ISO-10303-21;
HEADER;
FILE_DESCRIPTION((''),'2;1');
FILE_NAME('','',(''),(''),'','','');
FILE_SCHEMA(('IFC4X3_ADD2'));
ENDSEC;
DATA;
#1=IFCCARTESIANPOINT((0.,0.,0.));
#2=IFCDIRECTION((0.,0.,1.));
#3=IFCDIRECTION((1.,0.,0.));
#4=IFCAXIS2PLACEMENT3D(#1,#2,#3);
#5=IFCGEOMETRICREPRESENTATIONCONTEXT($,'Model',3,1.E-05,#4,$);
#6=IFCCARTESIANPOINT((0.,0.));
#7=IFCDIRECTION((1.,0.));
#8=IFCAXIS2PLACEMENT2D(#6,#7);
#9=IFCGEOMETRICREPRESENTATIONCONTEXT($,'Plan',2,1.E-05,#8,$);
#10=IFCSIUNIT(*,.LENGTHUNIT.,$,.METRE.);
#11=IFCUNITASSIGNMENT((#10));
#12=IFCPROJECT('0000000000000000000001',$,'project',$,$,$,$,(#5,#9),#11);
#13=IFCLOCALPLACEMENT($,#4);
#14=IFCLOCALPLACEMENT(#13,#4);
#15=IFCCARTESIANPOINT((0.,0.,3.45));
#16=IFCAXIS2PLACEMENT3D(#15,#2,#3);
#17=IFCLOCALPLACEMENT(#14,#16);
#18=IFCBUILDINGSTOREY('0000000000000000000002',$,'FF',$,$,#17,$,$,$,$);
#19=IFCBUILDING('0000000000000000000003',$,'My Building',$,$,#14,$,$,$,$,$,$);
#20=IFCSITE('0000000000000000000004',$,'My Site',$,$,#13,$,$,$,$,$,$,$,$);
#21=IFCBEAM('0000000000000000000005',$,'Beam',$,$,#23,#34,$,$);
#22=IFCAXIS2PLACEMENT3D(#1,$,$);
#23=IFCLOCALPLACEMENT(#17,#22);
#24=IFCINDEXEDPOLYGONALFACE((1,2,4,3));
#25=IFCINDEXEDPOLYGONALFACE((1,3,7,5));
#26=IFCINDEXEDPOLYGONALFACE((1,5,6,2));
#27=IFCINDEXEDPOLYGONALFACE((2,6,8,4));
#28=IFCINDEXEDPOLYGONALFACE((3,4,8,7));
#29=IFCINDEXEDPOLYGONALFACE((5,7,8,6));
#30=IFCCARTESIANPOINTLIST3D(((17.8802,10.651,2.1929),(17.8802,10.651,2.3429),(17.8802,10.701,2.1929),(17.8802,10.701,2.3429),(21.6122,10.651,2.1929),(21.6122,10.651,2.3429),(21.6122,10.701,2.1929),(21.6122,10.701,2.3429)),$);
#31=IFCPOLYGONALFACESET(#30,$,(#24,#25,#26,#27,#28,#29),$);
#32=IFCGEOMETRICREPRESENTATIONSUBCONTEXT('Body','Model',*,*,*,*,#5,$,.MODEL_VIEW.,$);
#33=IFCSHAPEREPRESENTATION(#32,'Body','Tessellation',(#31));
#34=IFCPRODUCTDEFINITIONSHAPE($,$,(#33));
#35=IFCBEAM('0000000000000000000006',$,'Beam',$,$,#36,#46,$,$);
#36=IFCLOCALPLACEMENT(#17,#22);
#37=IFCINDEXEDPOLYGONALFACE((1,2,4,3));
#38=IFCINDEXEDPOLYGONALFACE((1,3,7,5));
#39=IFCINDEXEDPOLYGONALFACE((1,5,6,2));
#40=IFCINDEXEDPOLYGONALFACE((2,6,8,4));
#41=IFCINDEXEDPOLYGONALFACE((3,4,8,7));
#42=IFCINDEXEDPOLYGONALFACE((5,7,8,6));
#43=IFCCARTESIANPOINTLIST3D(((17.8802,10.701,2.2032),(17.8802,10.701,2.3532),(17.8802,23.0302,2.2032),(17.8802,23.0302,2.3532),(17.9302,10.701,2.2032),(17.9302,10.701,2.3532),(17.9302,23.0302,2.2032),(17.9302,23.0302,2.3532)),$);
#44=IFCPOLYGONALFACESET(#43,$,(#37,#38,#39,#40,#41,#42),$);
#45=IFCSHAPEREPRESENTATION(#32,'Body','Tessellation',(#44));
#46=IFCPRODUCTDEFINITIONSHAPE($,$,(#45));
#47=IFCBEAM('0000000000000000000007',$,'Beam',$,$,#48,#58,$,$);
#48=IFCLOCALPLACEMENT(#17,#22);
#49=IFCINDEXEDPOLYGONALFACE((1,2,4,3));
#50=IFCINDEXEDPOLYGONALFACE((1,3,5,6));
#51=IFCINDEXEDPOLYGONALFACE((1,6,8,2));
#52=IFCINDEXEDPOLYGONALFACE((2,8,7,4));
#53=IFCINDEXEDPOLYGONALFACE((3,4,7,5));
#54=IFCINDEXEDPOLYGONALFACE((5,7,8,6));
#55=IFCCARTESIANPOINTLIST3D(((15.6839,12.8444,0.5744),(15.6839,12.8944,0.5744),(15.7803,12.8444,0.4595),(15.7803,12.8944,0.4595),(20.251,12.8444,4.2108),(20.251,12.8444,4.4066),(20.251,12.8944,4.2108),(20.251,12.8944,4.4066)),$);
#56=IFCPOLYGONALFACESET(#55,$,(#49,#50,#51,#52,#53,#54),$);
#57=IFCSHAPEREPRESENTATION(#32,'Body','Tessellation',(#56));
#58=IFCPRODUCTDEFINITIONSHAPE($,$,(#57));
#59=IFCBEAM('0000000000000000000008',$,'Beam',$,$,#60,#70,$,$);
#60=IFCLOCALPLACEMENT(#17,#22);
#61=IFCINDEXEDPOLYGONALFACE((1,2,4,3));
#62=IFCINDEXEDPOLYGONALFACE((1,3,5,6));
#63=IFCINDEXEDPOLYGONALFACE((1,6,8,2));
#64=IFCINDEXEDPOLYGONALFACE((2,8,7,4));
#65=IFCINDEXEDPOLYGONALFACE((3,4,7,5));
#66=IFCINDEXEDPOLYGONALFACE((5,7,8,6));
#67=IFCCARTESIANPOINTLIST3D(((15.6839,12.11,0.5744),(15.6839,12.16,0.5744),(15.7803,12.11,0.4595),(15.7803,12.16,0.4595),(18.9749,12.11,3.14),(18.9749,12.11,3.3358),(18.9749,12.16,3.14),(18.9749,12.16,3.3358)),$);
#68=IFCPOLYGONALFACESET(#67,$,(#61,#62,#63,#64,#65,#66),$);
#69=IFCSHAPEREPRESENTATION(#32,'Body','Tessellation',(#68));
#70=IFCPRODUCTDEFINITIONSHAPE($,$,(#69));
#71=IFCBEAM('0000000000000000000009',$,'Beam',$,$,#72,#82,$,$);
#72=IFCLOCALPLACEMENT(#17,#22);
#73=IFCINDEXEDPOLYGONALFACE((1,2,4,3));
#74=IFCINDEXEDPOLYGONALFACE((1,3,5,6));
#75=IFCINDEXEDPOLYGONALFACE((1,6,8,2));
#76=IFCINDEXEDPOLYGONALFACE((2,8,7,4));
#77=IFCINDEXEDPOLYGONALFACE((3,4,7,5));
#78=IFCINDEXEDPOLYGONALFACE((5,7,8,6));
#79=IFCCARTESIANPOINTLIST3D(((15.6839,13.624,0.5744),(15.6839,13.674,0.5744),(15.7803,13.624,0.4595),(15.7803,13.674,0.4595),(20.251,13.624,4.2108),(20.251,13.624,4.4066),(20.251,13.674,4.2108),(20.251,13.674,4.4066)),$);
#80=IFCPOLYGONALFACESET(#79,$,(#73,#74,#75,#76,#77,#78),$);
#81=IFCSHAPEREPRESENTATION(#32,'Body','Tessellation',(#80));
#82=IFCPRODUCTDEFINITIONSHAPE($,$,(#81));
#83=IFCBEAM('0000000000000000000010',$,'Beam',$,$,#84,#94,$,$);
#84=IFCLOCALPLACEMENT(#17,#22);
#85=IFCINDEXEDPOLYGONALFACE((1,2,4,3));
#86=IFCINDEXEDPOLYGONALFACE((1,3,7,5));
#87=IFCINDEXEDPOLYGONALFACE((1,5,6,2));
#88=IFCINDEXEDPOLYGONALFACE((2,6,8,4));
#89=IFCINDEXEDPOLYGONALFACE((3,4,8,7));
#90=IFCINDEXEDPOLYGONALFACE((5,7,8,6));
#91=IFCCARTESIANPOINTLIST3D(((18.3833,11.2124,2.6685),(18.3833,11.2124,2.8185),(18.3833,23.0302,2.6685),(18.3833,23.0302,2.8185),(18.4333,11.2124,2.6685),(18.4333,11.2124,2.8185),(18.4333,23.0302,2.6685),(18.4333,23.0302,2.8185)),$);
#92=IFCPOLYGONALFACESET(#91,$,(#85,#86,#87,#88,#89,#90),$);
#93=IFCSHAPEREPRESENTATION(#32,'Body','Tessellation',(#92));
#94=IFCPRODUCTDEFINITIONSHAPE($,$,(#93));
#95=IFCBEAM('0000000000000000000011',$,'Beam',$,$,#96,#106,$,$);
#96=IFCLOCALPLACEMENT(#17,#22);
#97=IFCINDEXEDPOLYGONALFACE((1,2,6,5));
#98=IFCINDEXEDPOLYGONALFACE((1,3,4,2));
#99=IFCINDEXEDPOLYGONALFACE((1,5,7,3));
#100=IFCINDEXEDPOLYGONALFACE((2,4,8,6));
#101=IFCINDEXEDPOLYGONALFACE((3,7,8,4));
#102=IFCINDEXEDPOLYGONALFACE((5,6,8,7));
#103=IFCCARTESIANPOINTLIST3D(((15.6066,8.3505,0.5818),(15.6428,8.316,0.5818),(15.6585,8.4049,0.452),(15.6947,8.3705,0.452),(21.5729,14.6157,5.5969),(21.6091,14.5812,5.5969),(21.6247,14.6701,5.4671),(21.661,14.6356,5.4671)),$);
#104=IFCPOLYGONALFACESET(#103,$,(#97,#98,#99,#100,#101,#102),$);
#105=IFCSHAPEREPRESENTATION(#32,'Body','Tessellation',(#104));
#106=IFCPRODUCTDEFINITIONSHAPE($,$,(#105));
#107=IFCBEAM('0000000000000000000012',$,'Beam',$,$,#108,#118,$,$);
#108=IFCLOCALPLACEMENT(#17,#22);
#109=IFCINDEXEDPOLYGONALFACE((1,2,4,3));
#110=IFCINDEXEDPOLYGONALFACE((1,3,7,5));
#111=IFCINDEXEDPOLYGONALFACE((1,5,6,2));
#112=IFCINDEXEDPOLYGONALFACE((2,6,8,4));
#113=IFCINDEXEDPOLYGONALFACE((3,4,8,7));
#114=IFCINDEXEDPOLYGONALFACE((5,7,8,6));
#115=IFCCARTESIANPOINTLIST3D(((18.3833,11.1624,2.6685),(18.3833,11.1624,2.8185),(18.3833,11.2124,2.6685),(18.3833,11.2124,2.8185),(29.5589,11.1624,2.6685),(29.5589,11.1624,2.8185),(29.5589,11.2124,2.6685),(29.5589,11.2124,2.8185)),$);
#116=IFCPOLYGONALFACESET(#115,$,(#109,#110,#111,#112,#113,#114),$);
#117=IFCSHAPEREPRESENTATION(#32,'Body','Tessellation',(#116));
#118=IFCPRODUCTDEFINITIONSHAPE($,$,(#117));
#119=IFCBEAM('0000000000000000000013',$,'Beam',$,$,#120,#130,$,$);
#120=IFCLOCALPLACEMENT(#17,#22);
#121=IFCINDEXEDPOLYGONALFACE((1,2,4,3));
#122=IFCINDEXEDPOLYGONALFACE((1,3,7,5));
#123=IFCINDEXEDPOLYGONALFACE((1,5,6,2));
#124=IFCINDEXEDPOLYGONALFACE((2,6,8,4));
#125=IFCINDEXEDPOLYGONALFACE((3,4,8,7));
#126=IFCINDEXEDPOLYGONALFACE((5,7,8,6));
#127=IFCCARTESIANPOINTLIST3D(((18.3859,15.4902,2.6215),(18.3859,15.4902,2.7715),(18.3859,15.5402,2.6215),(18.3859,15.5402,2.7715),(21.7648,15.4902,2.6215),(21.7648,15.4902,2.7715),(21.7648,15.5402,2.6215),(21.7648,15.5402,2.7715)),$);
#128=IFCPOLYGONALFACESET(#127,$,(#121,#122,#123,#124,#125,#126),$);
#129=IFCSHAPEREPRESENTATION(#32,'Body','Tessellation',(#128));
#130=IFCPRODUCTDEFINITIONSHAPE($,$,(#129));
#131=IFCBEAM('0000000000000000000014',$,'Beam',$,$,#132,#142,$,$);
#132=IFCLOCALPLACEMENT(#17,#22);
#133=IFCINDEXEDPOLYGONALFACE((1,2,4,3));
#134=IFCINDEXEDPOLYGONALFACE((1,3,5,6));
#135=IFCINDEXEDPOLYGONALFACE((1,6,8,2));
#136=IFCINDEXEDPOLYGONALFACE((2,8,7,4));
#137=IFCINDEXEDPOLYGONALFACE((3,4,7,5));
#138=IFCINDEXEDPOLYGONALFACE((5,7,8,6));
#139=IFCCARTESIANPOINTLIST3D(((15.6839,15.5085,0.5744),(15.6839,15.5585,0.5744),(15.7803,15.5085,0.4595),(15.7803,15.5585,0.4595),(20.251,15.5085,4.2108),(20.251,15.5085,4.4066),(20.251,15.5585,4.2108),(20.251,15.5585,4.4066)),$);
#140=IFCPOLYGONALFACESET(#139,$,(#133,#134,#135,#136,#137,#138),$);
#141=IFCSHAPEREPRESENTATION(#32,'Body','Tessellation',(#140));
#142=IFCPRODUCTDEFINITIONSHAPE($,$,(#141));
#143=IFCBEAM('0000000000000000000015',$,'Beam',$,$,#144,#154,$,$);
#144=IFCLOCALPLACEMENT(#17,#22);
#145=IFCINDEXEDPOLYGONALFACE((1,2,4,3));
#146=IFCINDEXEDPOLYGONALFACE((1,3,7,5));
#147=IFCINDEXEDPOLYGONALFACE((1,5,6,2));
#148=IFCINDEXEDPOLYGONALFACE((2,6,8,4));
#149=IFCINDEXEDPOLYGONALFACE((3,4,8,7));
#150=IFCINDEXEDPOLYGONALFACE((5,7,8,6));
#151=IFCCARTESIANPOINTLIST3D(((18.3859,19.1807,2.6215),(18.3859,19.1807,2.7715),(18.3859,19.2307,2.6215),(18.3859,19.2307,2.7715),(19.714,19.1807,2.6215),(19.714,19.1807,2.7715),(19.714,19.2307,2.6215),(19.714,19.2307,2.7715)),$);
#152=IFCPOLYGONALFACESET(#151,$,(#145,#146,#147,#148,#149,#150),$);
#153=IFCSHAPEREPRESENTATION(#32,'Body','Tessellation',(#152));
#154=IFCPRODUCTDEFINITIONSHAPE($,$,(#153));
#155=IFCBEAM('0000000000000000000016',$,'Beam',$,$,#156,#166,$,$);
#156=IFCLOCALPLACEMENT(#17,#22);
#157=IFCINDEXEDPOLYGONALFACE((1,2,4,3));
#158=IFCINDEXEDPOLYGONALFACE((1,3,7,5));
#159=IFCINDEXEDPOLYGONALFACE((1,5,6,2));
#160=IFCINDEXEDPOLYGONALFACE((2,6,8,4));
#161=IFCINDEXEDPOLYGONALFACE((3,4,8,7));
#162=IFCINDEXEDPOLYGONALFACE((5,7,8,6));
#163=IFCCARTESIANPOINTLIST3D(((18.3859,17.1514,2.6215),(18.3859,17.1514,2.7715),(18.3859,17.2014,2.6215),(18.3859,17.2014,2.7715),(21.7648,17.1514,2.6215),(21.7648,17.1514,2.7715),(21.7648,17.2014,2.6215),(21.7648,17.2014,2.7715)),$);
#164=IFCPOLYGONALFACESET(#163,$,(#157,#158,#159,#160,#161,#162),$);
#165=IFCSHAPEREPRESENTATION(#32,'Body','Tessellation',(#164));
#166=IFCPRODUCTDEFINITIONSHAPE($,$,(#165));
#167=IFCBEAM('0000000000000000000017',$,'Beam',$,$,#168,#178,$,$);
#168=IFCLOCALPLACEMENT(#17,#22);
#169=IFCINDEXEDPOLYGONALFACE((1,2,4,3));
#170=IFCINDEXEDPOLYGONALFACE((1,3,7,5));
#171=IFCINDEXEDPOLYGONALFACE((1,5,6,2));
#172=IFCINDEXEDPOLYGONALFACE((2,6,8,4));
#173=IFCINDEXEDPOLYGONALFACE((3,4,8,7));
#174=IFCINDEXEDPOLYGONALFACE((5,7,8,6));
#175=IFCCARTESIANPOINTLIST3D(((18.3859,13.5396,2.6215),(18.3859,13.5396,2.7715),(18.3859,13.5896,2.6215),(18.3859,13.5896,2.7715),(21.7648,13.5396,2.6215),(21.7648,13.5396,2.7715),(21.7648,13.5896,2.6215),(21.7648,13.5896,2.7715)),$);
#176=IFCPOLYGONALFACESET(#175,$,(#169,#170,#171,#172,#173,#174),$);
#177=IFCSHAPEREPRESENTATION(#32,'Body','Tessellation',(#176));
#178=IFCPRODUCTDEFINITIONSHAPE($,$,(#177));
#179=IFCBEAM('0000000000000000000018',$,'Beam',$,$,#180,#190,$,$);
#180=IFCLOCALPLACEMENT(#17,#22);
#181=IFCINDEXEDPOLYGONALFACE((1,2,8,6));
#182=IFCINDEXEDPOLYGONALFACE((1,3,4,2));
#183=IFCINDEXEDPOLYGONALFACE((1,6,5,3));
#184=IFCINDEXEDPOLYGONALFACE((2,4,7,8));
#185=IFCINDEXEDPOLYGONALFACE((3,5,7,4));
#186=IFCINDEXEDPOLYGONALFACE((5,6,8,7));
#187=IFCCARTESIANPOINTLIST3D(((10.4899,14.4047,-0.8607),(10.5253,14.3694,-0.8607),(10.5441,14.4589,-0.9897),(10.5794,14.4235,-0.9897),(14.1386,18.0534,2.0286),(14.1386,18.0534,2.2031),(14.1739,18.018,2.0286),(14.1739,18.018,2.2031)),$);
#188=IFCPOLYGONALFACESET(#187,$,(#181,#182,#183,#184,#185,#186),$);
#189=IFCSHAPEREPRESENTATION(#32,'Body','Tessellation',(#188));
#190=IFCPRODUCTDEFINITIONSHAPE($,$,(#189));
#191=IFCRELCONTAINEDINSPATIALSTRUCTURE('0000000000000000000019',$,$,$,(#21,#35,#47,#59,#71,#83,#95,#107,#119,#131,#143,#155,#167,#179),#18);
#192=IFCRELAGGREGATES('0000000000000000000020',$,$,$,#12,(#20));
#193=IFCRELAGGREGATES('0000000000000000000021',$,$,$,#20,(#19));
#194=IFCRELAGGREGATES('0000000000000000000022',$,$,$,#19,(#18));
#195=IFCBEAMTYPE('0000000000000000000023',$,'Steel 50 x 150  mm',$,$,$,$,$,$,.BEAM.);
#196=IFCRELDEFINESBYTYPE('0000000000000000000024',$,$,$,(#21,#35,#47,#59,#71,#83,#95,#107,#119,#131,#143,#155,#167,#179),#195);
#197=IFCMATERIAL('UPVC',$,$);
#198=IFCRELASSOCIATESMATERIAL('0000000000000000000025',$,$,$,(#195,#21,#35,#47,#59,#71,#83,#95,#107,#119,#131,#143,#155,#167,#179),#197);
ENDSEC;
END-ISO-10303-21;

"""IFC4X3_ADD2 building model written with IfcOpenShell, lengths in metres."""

from ifc_helpers import new_model, si_unit, frame, origin_with_axes, origin_2d_with_axis, place, context, subcontext, project, spatial, rectangle, extrude, clip, halfspace, material, material_profile, profile_set, profile_usage, type_object, element, save


model = new_model("IFC4X3_ADD2")

# Units and contexts
model_context = context("Model", 3, precision=1e-05, world=origin_with_axes())
plan_context = context("Plan", 2, precision=1e-05, world=origin_2d_with_axis())
body_context_1 = subcontext(model_context, "Body", "Model", "MODEL_VIEW")
ifc_project = project(units=[si_unit("LENGTHUNIT", "METRE")], contexts=[model_context, plan_context])

# Site, building, storey
site_placement = place(None, origin_with_axes())
site = spatial("IfcSite", under=ifc_project, at=site_placement, Name="My Site")
building_placement = place(site_placement, origin_with_axes())
building = spatial("IfcBuilding", under=site, at=building_placement, Name="My Building")
storey_placement = place(building_placement, frame((0.0, 0.0, 3.45), z_axis=(0.0, 0.0, 1.0), x_axis=(1.0, 0.0, 0.0)))
storey = spatial("IfcBuildingStorey", under=building, at=storey_placement, Name="FF")

# Beams
ifc_material_1 = material(Name="UPVC")
ifc_material_profile = material_profile(ifc_material_1, rectangle(XDim=0.05, YDim=0.15))
ifc_profile_set = profile_set([ifc_material_profile])
ifc_profile_usage_1 = profile_usage(ifc_profile_set)
beam_type = type_object("IfcBeamType", Name="Steel 50 x 150  mm", PredefinedType="BEAM", material=ifc_profile_set)
beam_1_placement = place(storey_placement, frame((17.8802, 10.676, 2.2679), z_axis=(1.0, 0.0, 0.0), x_axis=(0.0, 1.0, 0.0)))
element("IfcBeam", 1, at=beam_1_placement, inside=storey, type_object=beam_type, material=ifc_profile_usage_1, Name="Beam", context=body_context_1, shape_type="SweptSolid", body=[
    extrude(rectangle(XDim=0.05, YDim=0.15), origin_with_axes(), (0.0, 0.0, 1.0), 3.732),
])
ifc_profile_usage_2 = profile_usage(ifc_profile_set)
beam_2_placement = place(storey_placement, frame((17.9052, 10.701, 2.2782), z_axis=(0.0, 1.0, 0.0), x_axis=(-1.0, 0.0, 0.0)))
element("IfcBeam", 2, at=beam_2_placement, inside=storey, type_object=beam_type, material=ifc_profile_usage_2, Name="Beam", context=body_context_1, shape_type="SweptSolid", body=[
    extrude(rectangle(XDim=0.05, YDim=0.15), origin_with_axes(), (0.0, 0.0, 1.0), 12.3292),
])
ifc_profile_usage_3 = profile_usage(ifc_profile_set)
beam_3_placement = place(storey_placement, frame((15.7321, 12.8694, 0.5169), z_axis=(0.766044, 0.0, 0.642788), x_axis=(0.000001, 1.0, 0.0)))
element("IfcBeam", 3, at=beam_3_placement, inside=storey, type_object=beam_type, material=ifc_profile_usage_3, Name="Beam", context=body_context_1, shape_type="Clipping", body=[
    clip(extrude(rectangle(XDim=0.05, YDim=0.15), origin_with_axes(), (0.0, 0.0, 1.0), 6.049), halfspace(frame((-4.4092, -2.9047, 3.4617), z_axis=(0.0, -0.642788, 0.766044), x_axis=(-1.0, 0.0, 0.0)), False)),
])
ifc_profile_usage_4 = profile_usage(ifc_profile_set)
beam_4_placement = place(storey_placement, frame((15.7321, 12.135, 0.5169), z_axis=(0.766044, 0.0, 0.642788), x_axis=(0.000001, 1.0, 0.0)))
element("IfcBeam", 4, at=beam_4_placement, inside=storey, type_object=beam_type, material=ifc_profile_usage_4, Name="Beam", context=body_context_1, shape_type="Clipping", body=[
    clip(extrude(rectangle(XDim=0.05, YDim=0.15), origin_with_axes(), (0.0, 0.0, 1.0), 4.3831), halfspace(frame((-3.317, -2.0844, 2.4841), z_axis=(0.0, -0.642788, 0.766044), x_axis=(-1.0, 0.0, 0.0)), False)),
])
ifc_profile_usage_5 = profile_usage(ifc_profile_set)
beam_5_placement = place(storey_placement, frame((15.7321, 13.649, 0.5169), z_axis=(0.766044, 0.0, 0.642788), x_axis=(0.000001, 1.0, 0.0)))
element("IfcBeam", 5, at=beam_5_placement, inside=storey, type_object=beam_type, material=ifc_profile_usage_5, Name="Beam", context=body_context_1, shape_type="Clipping", body=[
    clip(extrude(rectangle(XDim=0.05, YDim=0.15), origin_with_axes(), (0.0, 0.0, 1.0), 6.049), halfspace(frame((-4.4092, -2.9047, 3.4617), z_axis=(0.0, -0.642788, 0.766044), x_axis=(-1.0, 0.0, 0.0)), False)),
])
ifc_profile_usage_6 = profile_usage(ifc_profile_set)
beam_6_placement = place(storey_placement, frame((18.4083, 11.2124, 2.7435), z_axis=(0.0, 1.0, 0.0), x_axis=(-1.0, 0.0, 0.0)))
element("IfcBeam", 6, at=beam_6_placement, inside=storey, type_object=beam_type, material=ifc_profile_usage_6, Name="Beam", context=body_context_1, shape_type="SweptSolid", body=[
    extrude(rectangle(XDim=0.05, YDim=0.15), origin_with_axes(), (0.0, 0.0, 1.0), 11.8178),
])
ifc_profile_usage_7 = profile_usage(ifc_profile_set)
beam_7_placement = place(storey_placement, frame((15.6507, 8.3605, 0.5169), z_axis=(0.596625, 0.626518, 0.501511), x_axis=(-0.724172, 0.68962, 0.0)))
element("IfcBeam", 7, at=beam_7_placement, inside=storey, type_object=beam_type, material=ifc_profile_usage_7, Name="Beam", context=body_context_1, shape_type="SweptSolid", body=[
    extrude(rectangle(XDim=0.05, YDim=0.15), origin_with_axes(), (0.0, 0.0, 1.0), 10.0),
])
ifc_profile_usage_8 = profile_usage(ifc_profile_set)
beam_8_placement = place(storey_placement, frame((18.3833, 11.1874, 2.7435), z_axis=(1.0, 0.0, 0.0), x_axis=(0.0, 1.0, 0.0)))
element("IfcBeam", 8, at=beam_8_placement, inside=storey, type_object=beam_type, material=ifc_profile_usage_8, Name="Beam", context=body_context_1, shape_type="SweptSolid", body=[
    extrude(rectangle(XDim=0.05, YDim=0.15), origin_with_axes(), (0.0, 0.0, 1.0), 11.1756),
])
ifc_profile_usage_9 = profile_usage(ifc_profile_set)
beam_9_placement = place(storey_placement, frame((18.3859, 15.5152, 2.6965), z_axis=(1.0, 0.0, 0.0), x_axis=(0.0, 1.0, 0.0)))
element("IfcBeam", 9, at=beam_9_placement, inside=storey, type_object=beam_type, material=ifc_profile_usage_9, Name="Beam", context=body_context_1, shape_type="SweptSolid", body=[
    extrude(rectangle(XDim=0.05, YDim=0.15), origin_with_axes(), (0.0, 0.0, 1.0), 3.3789),
])
ifc_profile_usage_10 = profile_usage(ifc_profile_set)
beam_10_placement = place(storey_placement, frame((15.7321, 15.5335, 0.5169), z_axis=(0.766044, 0.0, 0.642788), x_axis=(0.000001, 1.0, 0.0)))
element("IfcBeam", 10, at=beam_10_placement, inside=storey, type_object=beam_type, material=ifc_profile_usage_10, Name="Beam", context=body_context_1, shape_type="Clipping", body=[
    clip(extrude(rectangle(XDim=0.05, YDim=0.15), origin_with_axes(), (0.0, 0.0, 1.0), 6.049), halfspace(frame((-4.4092, -2.9047, 3.4617), z_axis=(0.0, -0.642788, 0.766044), x_axis=(-1.0, 0.0, 0.0)), False)),
])
ifc_profile_usage_11 = profile_usage(ifc_profile_set)
beam_11_placement = place(storey_placement, frame((18.3859, 19.2057, 2.6965), z_axis=(1.0, 0.0, 0.0), x_axis=(0.0, 1.0, 0.0)))
element("IfcBeam", 11, at=beam_11_placement, inside=storey, type_object=beam_type, material=ifc_profile_usage_11, Name="Beam", context=body_context_1, shape_type="SweptSolid", body=[
    extrude(rectangle(XDim=0.05, YDim=0.15), origin_with_axes(), (0.0, 0.0, 1.0), 1.3281),
])
ifc_profile_usage_12 = profile_usage(ifc_profile_set)
beam_12_placement = place(storey_placement, frame((18.3859, 17.1764, 2.6965), z_axis=(1.0, 0.0, 0.0), x_axis=(0.0, 1.0, 0.0)))
element("IfcBeam", 12, at=beam_12_placement, inside=storey, type_object=beam_type, material=ifc_profile_usage_12, Name="Beam", context=body_context_1, shape_type="SweptSolid", body=[
    extrude(rectangle(XDim=0.05, YDim=0.15), origin_with_axes(), (0.0, 0.0, 1.0), 3.3789),
])
ifc_profile_usage_13 = profile_usage(ifc_profile_set)
beam_13_placement = place(storey_placement, frame((18.3859, 13.5646, 2.6965), z_axis=(1.0, 0.0, 0.0), x_axis=(0.0, 1.0, 0.0)))
element("IfcBeam", 13, at=beam_13_placement, inside=storey, type_object=beam_type, material=ifc_profile_usage_13, Name="Beam", context=body_context_1, shape_type="SweptSolid", body=[
    extrude(rectangle(XDim=0.05, YDim=0.15), origin_with_axes(), (0.0, 0.0, 1.0), 3.3789),
])
ifc_profile_usage_14 = profile_usage(ifc_profile_set)
beam_14_placement = place(storey_placement, frame((10.5347, 14.4141, -0.9252), z_axis=(0.608008, 0.608007, 0.510543), x_axis=(-0.707106, 0.707107, 0.0)))
element("IfcBeam", 14, at=beam_14_placement, inside=storey, type_object=beam_type, material=ifc_profile_usage_14, Name="Beam", context=body_context_1, shape_type="Clipping", body=[
    clip(extrude(rectangle(XDim=0.05, YDim=0.15), origin_with_axes(), (0.0, 0.0, 1.0), 6.1064), halfspace(frame((5.1339, -2.6148, 4.4039), z_axis=(0.0, -0.510543, 0.859852), x_axis=(-1.0, 0.0, 0.0)), False)),
])

save(model, "model.ifc")
